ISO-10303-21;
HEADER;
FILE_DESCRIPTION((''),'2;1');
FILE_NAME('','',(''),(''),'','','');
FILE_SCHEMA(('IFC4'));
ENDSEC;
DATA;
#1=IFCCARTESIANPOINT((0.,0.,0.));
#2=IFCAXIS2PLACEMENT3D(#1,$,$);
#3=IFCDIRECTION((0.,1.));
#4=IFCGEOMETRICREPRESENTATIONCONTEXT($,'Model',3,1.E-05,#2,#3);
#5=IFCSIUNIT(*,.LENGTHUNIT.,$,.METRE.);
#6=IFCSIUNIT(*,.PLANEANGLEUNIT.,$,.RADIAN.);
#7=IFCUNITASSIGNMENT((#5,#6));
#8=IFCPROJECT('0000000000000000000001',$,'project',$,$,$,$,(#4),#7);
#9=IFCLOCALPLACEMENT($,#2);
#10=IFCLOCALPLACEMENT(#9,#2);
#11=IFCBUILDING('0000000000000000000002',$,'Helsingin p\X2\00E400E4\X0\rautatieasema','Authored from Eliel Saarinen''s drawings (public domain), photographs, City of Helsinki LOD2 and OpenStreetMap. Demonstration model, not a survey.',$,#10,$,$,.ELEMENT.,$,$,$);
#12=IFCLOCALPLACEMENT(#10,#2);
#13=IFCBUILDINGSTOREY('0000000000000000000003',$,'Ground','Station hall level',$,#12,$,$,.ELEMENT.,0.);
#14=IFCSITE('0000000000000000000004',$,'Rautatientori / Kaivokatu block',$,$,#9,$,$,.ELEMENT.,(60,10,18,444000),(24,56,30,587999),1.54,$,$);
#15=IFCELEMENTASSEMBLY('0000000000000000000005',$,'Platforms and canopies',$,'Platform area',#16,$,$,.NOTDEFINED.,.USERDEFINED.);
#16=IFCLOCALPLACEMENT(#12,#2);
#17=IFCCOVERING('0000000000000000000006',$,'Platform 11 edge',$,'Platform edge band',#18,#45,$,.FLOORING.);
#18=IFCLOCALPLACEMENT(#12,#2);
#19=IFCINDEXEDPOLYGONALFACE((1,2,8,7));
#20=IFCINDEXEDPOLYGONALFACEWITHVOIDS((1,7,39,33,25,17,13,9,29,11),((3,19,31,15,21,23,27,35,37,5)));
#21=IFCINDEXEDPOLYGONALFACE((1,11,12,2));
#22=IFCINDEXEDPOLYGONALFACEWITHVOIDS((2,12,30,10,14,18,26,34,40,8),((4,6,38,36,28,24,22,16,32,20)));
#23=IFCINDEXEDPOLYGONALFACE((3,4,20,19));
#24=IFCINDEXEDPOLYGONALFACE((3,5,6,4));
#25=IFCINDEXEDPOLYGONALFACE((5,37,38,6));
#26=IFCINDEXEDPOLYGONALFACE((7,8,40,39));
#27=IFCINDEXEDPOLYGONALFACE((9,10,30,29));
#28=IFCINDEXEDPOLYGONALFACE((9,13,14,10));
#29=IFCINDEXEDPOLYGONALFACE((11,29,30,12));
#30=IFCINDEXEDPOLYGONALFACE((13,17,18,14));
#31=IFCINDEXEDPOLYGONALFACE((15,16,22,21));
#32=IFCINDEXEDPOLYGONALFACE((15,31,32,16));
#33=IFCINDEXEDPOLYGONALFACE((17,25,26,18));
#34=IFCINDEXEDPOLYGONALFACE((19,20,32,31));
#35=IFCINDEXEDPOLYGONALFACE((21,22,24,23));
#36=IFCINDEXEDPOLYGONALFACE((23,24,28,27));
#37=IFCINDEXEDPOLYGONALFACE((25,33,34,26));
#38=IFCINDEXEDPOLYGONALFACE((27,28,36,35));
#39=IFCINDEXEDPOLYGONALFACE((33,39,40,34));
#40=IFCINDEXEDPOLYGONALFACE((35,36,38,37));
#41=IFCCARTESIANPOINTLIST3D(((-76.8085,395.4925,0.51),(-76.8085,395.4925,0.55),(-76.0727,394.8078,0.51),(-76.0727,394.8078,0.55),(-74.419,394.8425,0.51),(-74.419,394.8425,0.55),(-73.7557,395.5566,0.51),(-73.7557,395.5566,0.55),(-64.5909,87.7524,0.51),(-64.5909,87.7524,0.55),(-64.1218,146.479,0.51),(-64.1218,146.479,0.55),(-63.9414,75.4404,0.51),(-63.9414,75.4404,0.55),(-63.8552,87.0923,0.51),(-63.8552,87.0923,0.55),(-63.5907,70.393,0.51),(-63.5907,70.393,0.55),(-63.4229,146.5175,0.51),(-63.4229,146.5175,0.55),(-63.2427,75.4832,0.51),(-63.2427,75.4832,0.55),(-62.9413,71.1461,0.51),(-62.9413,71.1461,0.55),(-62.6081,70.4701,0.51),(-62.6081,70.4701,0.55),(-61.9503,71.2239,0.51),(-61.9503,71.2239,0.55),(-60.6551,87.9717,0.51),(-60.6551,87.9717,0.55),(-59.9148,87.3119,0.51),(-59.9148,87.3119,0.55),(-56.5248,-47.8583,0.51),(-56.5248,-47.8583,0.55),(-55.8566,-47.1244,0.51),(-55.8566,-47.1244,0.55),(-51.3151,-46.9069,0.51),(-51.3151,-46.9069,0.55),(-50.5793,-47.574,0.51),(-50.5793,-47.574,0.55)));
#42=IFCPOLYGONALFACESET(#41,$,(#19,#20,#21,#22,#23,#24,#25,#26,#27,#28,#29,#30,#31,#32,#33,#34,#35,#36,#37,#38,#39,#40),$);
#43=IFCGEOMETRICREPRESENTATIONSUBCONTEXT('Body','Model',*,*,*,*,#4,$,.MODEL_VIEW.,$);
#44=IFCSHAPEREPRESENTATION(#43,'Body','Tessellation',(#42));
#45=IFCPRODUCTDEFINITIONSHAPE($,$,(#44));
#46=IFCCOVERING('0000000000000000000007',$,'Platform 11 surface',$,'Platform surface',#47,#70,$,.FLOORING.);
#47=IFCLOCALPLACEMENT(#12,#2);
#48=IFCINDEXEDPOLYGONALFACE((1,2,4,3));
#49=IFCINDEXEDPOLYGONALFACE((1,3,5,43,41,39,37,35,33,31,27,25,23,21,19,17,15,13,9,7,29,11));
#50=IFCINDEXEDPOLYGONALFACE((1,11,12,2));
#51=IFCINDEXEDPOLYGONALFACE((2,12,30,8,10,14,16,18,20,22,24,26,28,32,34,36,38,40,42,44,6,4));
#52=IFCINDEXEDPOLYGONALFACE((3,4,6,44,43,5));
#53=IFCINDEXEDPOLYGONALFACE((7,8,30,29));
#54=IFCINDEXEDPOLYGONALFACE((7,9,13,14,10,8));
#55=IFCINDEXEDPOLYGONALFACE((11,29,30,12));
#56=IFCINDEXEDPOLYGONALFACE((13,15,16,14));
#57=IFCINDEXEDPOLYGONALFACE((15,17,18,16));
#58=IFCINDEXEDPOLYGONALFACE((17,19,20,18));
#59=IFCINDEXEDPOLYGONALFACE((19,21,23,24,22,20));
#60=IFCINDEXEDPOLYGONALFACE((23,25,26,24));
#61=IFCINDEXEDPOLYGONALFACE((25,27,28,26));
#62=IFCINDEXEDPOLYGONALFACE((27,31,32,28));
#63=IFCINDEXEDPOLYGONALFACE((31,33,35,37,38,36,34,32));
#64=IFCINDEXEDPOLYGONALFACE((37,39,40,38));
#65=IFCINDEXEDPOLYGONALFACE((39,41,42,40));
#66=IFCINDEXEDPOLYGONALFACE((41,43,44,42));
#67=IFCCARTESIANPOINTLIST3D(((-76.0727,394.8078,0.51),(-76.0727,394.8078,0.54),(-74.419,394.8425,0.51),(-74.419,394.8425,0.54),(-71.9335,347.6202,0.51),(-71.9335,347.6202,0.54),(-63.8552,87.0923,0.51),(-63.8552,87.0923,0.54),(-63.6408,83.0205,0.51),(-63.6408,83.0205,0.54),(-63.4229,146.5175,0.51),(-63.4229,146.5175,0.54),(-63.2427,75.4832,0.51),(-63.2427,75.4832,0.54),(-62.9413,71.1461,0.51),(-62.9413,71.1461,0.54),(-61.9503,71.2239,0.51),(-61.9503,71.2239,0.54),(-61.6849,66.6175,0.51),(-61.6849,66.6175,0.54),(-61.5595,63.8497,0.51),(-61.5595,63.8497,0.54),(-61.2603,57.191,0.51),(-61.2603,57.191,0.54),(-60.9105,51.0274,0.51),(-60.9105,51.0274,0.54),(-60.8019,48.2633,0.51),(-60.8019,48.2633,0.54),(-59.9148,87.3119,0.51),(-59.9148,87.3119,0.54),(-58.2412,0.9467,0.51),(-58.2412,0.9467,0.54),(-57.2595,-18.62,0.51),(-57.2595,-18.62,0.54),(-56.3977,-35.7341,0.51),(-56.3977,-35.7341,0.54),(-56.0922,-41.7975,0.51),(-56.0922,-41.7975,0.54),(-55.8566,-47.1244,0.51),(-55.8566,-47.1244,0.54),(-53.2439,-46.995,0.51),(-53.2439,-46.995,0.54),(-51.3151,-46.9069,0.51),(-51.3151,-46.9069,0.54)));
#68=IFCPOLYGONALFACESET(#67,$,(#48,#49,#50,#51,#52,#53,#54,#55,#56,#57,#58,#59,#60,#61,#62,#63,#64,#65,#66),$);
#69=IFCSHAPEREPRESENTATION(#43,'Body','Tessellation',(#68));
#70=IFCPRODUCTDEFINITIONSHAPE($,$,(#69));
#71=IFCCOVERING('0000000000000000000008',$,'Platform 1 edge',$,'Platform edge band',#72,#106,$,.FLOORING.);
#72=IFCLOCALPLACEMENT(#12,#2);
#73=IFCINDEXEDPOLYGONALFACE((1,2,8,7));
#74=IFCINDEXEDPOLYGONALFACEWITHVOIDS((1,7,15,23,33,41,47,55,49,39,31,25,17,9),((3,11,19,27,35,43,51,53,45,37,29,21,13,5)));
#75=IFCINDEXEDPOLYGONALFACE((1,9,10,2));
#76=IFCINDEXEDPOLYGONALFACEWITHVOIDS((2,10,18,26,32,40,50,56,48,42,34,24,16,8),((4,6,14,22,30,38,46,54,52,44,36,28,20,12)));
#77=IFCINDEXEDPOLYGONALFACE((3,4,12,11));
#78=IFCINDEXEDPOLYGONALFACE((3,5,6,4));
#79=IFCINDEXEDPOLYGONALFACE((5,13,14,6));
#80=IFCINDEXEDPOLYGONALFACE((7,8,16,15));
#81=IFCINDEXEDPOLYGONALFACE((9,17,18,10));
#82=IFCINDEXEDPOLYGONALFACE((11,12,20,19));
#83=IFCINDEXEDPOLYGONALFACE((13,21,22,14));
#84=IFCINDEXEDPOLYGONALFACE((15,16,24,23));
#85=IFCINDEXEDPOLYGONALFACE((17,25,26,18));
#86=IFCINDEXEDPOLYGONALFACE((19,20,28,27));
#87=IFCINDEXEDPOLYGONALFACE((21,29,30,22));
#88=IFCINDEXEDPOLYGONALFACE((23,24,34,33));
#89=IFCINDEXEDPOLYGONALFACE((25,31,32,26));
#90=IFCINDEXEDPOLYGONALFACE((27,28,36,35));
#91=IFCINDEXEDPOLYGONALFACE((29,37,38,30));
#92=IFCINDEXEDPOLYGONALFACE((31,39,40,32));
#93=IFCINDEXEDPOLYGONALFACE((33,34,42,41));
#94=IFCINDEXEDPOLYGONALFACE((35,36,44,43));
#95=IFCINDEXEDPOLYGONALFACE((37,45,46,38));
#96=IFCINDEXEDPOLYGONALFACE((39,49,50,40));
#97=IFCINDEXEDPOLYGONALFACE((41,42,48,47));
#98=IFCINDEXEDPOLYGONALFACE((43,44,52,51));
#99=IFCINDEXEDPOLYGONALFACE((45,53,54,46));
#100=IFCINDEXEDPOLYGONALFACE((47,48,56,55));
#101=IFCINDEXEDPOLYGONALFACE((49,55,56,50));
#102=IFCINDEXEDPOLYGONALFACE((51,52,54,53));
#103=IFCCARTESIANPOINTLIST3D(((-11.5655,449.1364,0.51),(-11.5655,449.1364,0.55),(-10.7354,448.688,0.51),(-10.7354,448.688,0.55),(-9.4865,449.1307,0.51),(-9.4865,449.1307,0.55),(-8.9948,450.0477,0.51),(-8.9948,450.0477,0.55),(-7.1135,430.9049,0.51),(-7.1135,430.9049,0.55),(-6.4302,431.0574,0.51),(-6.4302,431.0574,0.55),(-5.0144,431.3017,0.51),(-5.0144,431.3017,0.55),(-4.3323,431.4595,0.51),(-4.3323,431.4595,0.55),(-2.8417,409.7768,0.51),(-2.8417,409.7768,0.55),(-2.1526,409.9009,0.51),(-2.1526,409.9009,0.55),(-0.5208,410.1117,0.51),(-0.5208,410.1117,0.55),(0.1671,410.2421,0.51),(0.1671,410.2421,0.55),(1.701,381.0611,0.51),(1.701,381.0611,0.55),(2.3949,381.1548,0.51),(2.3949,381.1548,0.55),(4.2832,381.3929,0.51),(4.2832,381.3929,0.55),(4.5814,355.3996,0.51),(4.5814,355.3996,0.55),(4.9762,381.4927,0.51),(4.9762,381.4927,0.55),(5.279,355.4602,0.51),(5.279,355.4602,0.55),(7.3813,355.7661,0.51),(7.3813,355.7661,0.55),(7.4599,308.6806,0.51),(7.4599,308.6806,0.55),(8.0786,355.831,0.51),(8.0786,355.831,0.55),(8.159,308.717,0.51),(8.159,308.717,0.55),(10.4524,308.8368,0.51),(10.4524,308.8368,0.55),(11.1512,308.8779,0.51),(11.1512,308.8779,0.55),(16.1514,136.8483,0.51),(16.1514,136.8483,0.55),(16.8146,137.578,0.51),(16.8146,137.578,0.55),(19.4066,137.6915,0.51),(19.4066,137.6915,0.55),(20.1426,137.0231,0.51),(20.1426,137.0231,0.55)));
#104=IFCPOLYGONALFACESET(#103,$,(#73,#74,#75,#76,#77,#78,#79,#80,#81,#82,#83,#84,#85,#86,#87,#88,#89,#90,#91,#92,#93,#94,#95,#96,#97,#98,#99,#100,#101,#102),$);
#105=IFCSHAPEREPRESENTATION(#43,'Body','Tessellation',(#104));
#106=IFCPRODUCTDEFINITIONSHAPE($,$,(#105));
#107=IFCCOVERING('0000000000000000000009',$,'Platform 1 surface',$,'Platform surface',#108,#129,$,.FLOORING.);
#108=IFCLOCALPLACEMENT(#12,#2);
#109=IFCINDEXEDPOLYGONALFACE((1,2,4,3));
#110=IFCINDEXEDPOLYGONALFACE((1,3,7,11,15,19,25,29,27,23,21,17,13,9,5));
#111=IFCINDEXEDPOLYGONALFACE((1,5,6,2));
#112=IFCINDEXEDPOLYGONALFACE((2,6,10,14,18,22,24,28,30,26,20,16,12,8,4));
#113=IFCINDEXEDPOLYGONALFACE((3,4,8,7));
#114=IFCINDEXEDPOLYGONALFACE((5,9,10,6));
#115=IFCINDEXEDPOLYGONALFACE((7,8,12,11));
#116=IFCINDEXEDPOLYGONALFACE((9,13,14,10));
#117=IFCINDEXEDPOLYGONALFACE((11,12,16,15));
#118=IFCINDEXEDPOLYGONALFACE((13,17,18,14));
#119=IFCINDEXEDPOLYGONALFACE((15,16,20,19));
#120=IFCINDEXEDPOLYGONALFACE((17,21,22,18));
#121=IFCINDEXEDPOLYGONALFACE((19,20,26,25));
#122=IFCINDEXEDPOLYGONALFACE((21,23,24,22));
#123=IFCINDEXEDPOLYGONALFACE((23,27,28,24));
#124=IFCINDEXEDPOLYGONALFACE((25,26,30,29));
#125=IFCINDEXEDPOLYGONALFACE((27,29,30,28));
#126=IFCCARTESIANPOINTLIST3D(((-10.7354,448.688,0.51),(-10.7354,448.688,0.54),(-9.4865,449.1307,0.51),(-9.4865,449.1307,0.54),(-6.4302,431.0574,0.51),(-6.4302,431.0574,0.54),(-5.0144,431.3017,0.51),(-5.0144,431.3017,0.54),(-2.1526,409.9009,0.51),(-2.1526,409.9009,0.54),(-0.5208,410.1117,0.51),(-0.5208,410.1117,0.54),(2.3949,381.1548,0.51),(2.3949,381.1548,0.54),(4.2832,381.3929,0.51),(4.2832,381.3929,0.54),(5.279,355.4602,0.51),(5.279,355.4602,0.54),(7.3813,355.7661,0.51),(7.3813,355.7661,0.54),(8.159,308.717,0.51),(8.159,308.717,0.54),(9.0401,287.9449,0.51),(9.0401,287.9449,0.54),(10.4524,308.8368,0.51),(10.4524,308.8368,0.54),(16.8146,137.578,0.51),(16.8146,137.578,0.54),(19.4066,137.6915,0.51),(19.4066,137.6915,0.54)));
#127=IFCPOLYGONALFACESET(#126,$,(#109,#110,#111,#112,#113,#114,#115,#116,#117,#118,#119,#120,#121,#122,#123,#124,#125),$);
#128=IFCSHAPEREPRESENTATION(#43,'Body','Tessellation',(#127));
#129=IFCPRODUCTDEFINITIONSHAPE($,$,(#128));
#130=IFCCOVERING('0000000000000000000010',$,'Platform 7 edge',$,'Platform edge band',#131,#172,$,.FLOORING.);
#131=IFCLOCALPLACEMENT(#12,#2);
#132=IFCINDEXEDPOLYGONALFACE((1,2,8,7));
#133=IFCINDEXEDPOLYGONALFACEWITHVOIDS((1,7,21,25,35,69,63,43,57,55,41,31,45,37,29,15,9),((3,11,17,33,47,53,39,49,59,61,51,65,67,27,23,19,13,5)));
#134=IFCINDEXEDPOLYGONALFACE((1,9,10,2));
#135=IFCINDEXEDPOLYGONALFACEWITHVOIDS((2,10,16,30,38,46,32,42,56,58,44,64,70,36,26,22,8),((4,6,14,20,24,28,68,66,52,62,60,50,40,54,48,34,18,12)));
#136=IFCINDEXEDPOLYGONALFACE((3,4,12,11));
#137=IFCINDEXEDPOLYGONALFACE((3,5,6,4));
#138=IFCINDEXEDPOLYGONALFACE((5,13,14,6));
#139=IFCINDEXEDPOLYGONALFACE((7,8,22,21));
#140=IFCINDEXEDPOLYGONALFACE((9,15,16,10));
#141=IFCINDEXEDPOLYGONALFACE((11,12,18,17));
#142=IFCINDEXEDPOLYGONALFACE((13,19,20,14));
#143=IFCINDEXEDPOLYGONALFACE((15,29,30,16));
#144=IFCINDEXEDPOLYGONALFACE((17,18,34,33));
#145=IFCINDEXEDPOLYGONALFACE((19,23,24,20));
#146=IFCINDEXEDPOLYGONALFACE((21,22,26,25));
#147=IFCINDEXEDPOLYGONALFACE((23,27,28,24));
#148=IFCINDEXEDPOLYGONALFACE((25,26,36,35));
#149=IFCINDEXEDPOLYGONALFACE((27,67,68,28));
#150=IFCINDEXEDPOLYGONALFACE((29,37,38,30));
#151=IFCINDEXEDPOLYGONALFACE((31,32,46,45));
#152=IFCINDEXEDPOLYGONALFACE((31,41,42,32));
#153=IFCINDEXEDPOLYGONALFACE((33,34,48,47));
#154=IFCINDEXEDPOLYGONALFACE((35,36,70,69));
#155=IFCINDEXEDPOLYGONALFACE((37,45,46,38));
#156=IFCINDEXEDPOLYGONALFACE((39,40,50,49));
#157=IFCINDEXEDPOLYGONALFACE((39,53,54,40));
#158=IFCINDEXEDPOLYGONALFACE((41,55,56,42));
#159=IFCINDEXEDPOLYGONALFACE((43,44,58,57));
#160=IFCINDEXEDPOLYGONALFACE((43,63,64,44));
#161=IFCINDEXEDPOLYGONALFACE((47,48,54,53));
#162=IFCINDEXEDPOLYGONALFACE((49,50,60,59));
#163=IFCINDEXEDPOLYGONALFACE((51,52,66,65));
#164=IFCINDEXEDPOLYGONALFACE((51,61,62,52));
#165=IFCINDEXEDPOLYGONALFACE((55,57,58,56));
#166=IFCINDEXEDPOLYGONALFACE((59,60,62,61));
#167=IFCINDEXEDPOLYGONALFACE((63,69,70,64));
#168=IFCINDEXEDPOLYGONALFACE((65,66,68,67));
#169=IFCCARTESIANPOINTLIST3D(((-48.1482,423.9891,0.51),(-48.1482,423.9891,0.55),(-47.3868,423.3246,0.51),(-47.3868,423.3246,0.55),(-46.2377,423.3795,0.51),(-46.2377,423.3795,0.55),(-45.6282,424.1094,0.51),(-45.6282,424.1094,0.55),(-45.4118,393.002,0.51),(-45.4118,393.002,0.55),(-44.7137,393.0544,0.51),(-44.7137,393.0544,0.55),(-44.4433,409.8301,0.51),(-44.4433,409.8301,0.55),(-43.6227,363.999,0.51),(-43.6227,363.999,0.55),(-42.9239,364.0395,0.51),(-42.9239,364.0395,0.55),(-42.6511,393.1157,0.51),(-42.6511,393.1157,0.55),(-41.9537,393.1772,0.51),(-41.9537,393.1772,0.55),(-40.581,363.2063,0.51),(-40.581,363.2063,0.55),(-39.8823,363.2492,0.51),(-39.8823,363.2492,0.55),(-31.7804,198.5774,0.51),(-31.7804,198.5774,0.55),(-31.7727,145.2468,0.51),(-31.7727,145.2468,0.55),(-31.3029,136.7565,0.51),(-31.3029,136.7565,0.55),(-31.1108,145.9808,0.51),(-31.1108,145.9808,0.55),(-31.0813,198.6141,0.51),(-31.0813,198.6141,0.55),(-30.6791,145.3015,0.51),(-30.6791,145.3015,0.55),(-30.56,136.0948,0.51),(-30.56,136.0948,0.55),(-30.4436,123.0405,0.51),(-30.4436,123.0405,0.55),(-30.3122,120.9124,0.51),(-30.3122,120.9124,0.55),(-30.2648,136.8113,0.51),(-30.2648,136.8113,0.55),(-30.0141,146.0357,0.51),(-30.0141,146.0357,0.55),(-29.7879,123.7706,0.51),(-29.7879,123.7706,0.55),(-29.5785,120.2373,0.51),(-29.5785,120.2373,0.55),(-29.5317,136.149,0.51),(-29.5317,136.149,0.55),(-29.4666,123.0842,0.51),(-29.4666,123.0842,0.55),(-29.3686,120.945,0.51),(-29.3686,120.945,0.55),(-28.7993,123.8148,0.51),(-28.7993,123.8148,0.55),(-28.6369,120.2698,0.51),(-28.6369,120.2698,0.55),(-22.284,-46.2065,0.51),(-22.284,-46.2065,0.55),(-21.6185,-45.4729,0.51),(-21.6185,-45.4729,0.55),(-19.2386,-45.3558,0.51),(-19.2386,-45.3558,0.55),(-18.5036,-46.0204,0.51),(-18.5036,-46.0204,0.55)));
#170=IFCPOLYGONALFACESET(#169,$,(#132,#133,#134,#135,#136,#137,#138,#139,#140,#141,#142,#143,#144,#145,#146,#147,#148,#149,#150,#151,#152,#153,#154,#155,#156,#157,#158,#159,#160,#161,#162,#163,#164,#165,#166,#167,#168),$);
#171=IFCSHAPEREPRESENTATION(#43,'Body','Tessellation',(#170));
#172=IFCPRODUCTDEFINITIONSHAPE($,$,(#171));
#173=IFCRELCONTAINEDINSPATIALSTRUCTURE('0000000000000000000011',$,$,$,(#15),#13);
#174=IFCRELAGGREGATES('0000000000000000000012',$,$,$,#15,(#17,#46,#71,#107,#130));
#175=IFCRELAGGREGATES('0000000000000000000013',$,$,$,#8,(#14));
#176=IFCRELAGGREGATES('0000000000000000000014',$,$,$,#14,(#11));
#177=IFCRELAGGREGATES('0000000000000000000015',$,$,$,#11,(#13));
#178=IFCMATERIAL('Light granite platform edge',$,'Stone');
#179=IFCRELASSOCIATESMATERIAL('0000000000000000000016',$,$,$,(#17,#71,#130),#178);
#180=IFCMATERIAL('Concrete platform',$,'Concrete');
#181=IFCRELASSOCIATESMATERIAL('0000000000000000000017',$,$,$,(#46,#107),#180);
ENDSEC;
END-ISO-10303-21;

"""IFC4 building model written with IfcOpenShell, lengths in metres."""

from ifc_helpers import new_model, si_unit, direction, frame, origin, place, context, subcontext, project, spatial, polyline, outline, extrude, material, element, aggregate, save


model = new_model("IFC4")

# Units and contexts
model_context = context("Model", 3, precision=1e-05, world=origin(), true_north=direction((0.0, 1.0)))
body_context = subcontext(model_context, "Body", "Model", "MODEL_VIEW")
ifc_project = project(units=[si_unit("LENGTHUNIT", "METRE"), si_unit("PLANEANGLEUNIT", "RADIAN")], contexts=[model_context])

# Site, building, storey
site_placement = place(None, origin())
site = spatial("IfcSite", under=ifc_project, at=site_placement, Name="Rautatientori / Kaivokatu block", CompositionType="ELEMENT", RefLatitude=(60, 10, 18, 444000), RefLongitude=(24, 56, 30, 587999), RefElevation=1.54)
building_placement = place(site_placement, origin())
building = spatial("IfcBuilding", under=site, at=building_placement, Name="Helsingin päärautatieasema", Description="Authored from Eliel Saarinen's drawings (public domain), photographs, City of Helsinki LOD2 and OpenStreetMap. Demonstration model, not a survey.", CompositionType="ELEMENT")
storey_placement = place(building_placement, origin())
storey = spatial("IfcBuildingStorey", under=building, at=storey_placement, Name="Ground", Description="Station hall level", CompositionType="ELEMENT", Elevation=0.0)

# Element assembly, coverings
assembly_placement = place(building_placement, origin())
assembly = element("IfcElementAssembly", 1, at=assembly_placement, inside=storey, Name="Platforms and canopies", ObjectType="Platform area", AssemblyPlace="NOTDEFINED", PredefinedType="USERDEFINED")
ifc_material_1 = material(Name="Concrete platform", Category="Concrete")
ifc_material_2 = material(Name="Light granite platform edge", Category="Stone")
covering_1_placement = place(building_placement, origin())
covering_1 = element("IfcCovering", 2, at=covering_1_placement, material=ifc_material_2, Name="Platform 11 edge", ObjectType="Platform edge band", PredefinedType="FLOORING", context=body_context, shape_type="SweptSolid", body=[
    extrude(outline(polyline([(-76.8085, 395.4925), (-73.7557, 395.5566), (-50.5793, -47.574), (-56.5248, -47.8583), (-62.6081, 70.4701), (-63.5907, 70.393), (-63.9414, 75.4404), (-64.5909, 87.7524), (-60.6551, 87.9717), (-64.1218, 146.479), (-76.8085, 395.4925)]), holes=[polyline([(-76.0727, 394.8078), (-74.419, 394.8425), (-51.3151, -46.9069), (-55.8566, -47.1244), (-61.9503, 71.2239), (-62.9413, 71.1461), (-63.2427, 75.4832), (-63.8552, 87.0923), (-59.9148, 87.3119), (-63.4229, 146.5175), (-76.0727, 394.8078)])]), frame((0.0, 0.0, 0.51)), (0.0, 0.0, 1.0), 0.04),
])
covering_2_placement = place(building_placement, origin())
covering_2 = element("IfcCovering", 3, at=covering_2_placement, material=ifc_material_1, Name="Platform 11 surface", ObjectType="Platform surface", PredefinedType="FLOORING", context=body_context, shape_type="SweptSolid", body=[
    extrude(outline(polyline([(-76.0727, 394.8078), (-74.419, 394.8425), (-71.9335, 347.6202), (-51.3151, -46.9069), (-53.2439, -46.995), (-55.8566, -47.1244), (-56.0922, -41.7975), (-56.3977, -35.7341), (-57.2595, -18.62), (-58.2412, 0.9467), (-60.8019, 48.2633), (-60.9105, 51.0274), (-61.2603, 57.191), (-61.5595, 63.8497), (-61.6849, 66.6175), (-61.9503, 71.2239), (-62.9413, 71.1461), (-63.2427, 75.4832), (-63.6408, 83.0205), (-63.8552, 87.0923), (-59.9148, 87.3119), (-63.4229, 146.5175), (-76.0727, 394.8078)])), frame((0.0, 0.0, 0.51)), (0.0, 0.0, 1.0), 0.03),
])
covering_3_placement = place(building_placement, origin())
covering_3 = element("IfcCovering", 4, at=covering_3_placement, material=ifc_material_2, Name="Platform 1 edge", ObjectType="Platform edge band", PredefinedType="FLOORING", context=body_context, shape_type="SweptSolid", body=[
    extrude(outline(polyline([(20.1426, 137.0231), (16.1514, 136.8483), (7.4599, 308.6806), (4.5814, 355.3996), (1.701, 381.0611), (-2.8417, 409.7768), (-7.1135, 430.9049), (-11.5655, 449.1364), (-8.9948, 450.0477), (-4.3323, 431.4595), (0.1671, 410.2421), (4.9762, 381.4927), (8.0786, 355.831), (11.1512, 308.8779), (20.1426, 137.0231)]), holes=[polyline([(19.4066, 137.6915), (16.8146, 137.578), (8.159, 308.717), (5.279, 355.4602), (2.3949, 381.1548), (-2.1526, 409.9009), (-6.4302, 431.0574), (-10.7354, 448.688), (-9.4865, 449.1307), (-5.0144, 431.3017), (-0.5208, 410.1117), (4.2832, 381.3929), (7.3813, 355.7661), (10.4524, 308.8368), (19.4066, 137.6915)])]), frame((0.0, 0.0, 0.51)), (0.0, 0.0, 1.0), 0.04),
])
covering_4_placement = place(building_placement, origin())
covering_4 = element("IfcCovering", 5, at=covering_4_placement, material=ifc_material_1, Name="Platform 1 surface", ObjectType="Platform surface", PredefinedType="FLOORING", context=body_context, shape_type="SweptSolid", body=[
    extrude(outline(polyline([(19.4066, 137.6915), (16.8146, 137.578), (9.0401, 287.9449), (8.159, 308.717), (5.279, 355.4602), (2.3949, 381.1548), (-2.1526, 409.9009), (-6.4302, 431.0574), (-10.7354, 448.688), (-9.4865, 449.1307), (-5.0144, 431.3017), (-0.5208, 410.1117), (4.2832, 381.3929), (7.3813, 355.7661), (10.4524, 308.8368), (19.4066, 137.6915)])), frame((0.0, 0.0, 0.51)), (0.0, 0.0, 1.0), 0.03),
])
covering_5_placement = place(building_placement, origin())
covering_5 = element("IfcCovering", 6, at=covering_5_placement, material=ifc_material_2, Name="Platform 7 edge", ObjectType="Platform edge band", PredefinedType="FLOORING", context=body_context, shape_type="SweptSolid", body=[
    extrude(outline(polyline([(-18.5036, -46.0204), (-22.284, -46.2065), (-30.3122, 120.9124), (-29.3686, 120.945), (-29.4666, 123.0842), (-30.4436, 123.0405), (-31.3029, 136.7565), (-30.2648, 136.8113), (-30.6791, 145.3015), (-31.7727, 145.2468), (-43.6227, 363.999), (-45.4118, 393.002), (-48.1482, 423.9891), (-45.6282, 424.1094), (-41.9537, 393.1772), (-39.8823, 363.2492), (-31.0813, 198.6141), (-18.5036, -46.0204)]), holes=[polyline([(-19.2386, -45.3558), (-21.6185, -45.4729), (-29.5785, 120.2373), (-28.6369, 120.2698), (-28.7993, 123.8148), (-29.7879, 123.7706), (-30.56, 136.0948), (-29.5317, 136.149), (-30.0141, 146.0357), (-31.1108, 145.9808), (-42.9239, 364.0395), (-44.7137, 393.0544), (-47.3868, 423.3246), (-46.2377, 423.3795), (-44.4433, 409.8301), (-42.6511, 393.1157), (-40.581, 363.2063), (-31.7804, 198.5774), (-19.2386, -45.3558)])]), frame((0.0, 0.0, 0.51)), (0.0, 0.0, 1.0), 0.04),
])
aggregate(assembly, [covering_1, covering_2, covering_3, covering_4, covering_5])

save(model, "model.ifc")
